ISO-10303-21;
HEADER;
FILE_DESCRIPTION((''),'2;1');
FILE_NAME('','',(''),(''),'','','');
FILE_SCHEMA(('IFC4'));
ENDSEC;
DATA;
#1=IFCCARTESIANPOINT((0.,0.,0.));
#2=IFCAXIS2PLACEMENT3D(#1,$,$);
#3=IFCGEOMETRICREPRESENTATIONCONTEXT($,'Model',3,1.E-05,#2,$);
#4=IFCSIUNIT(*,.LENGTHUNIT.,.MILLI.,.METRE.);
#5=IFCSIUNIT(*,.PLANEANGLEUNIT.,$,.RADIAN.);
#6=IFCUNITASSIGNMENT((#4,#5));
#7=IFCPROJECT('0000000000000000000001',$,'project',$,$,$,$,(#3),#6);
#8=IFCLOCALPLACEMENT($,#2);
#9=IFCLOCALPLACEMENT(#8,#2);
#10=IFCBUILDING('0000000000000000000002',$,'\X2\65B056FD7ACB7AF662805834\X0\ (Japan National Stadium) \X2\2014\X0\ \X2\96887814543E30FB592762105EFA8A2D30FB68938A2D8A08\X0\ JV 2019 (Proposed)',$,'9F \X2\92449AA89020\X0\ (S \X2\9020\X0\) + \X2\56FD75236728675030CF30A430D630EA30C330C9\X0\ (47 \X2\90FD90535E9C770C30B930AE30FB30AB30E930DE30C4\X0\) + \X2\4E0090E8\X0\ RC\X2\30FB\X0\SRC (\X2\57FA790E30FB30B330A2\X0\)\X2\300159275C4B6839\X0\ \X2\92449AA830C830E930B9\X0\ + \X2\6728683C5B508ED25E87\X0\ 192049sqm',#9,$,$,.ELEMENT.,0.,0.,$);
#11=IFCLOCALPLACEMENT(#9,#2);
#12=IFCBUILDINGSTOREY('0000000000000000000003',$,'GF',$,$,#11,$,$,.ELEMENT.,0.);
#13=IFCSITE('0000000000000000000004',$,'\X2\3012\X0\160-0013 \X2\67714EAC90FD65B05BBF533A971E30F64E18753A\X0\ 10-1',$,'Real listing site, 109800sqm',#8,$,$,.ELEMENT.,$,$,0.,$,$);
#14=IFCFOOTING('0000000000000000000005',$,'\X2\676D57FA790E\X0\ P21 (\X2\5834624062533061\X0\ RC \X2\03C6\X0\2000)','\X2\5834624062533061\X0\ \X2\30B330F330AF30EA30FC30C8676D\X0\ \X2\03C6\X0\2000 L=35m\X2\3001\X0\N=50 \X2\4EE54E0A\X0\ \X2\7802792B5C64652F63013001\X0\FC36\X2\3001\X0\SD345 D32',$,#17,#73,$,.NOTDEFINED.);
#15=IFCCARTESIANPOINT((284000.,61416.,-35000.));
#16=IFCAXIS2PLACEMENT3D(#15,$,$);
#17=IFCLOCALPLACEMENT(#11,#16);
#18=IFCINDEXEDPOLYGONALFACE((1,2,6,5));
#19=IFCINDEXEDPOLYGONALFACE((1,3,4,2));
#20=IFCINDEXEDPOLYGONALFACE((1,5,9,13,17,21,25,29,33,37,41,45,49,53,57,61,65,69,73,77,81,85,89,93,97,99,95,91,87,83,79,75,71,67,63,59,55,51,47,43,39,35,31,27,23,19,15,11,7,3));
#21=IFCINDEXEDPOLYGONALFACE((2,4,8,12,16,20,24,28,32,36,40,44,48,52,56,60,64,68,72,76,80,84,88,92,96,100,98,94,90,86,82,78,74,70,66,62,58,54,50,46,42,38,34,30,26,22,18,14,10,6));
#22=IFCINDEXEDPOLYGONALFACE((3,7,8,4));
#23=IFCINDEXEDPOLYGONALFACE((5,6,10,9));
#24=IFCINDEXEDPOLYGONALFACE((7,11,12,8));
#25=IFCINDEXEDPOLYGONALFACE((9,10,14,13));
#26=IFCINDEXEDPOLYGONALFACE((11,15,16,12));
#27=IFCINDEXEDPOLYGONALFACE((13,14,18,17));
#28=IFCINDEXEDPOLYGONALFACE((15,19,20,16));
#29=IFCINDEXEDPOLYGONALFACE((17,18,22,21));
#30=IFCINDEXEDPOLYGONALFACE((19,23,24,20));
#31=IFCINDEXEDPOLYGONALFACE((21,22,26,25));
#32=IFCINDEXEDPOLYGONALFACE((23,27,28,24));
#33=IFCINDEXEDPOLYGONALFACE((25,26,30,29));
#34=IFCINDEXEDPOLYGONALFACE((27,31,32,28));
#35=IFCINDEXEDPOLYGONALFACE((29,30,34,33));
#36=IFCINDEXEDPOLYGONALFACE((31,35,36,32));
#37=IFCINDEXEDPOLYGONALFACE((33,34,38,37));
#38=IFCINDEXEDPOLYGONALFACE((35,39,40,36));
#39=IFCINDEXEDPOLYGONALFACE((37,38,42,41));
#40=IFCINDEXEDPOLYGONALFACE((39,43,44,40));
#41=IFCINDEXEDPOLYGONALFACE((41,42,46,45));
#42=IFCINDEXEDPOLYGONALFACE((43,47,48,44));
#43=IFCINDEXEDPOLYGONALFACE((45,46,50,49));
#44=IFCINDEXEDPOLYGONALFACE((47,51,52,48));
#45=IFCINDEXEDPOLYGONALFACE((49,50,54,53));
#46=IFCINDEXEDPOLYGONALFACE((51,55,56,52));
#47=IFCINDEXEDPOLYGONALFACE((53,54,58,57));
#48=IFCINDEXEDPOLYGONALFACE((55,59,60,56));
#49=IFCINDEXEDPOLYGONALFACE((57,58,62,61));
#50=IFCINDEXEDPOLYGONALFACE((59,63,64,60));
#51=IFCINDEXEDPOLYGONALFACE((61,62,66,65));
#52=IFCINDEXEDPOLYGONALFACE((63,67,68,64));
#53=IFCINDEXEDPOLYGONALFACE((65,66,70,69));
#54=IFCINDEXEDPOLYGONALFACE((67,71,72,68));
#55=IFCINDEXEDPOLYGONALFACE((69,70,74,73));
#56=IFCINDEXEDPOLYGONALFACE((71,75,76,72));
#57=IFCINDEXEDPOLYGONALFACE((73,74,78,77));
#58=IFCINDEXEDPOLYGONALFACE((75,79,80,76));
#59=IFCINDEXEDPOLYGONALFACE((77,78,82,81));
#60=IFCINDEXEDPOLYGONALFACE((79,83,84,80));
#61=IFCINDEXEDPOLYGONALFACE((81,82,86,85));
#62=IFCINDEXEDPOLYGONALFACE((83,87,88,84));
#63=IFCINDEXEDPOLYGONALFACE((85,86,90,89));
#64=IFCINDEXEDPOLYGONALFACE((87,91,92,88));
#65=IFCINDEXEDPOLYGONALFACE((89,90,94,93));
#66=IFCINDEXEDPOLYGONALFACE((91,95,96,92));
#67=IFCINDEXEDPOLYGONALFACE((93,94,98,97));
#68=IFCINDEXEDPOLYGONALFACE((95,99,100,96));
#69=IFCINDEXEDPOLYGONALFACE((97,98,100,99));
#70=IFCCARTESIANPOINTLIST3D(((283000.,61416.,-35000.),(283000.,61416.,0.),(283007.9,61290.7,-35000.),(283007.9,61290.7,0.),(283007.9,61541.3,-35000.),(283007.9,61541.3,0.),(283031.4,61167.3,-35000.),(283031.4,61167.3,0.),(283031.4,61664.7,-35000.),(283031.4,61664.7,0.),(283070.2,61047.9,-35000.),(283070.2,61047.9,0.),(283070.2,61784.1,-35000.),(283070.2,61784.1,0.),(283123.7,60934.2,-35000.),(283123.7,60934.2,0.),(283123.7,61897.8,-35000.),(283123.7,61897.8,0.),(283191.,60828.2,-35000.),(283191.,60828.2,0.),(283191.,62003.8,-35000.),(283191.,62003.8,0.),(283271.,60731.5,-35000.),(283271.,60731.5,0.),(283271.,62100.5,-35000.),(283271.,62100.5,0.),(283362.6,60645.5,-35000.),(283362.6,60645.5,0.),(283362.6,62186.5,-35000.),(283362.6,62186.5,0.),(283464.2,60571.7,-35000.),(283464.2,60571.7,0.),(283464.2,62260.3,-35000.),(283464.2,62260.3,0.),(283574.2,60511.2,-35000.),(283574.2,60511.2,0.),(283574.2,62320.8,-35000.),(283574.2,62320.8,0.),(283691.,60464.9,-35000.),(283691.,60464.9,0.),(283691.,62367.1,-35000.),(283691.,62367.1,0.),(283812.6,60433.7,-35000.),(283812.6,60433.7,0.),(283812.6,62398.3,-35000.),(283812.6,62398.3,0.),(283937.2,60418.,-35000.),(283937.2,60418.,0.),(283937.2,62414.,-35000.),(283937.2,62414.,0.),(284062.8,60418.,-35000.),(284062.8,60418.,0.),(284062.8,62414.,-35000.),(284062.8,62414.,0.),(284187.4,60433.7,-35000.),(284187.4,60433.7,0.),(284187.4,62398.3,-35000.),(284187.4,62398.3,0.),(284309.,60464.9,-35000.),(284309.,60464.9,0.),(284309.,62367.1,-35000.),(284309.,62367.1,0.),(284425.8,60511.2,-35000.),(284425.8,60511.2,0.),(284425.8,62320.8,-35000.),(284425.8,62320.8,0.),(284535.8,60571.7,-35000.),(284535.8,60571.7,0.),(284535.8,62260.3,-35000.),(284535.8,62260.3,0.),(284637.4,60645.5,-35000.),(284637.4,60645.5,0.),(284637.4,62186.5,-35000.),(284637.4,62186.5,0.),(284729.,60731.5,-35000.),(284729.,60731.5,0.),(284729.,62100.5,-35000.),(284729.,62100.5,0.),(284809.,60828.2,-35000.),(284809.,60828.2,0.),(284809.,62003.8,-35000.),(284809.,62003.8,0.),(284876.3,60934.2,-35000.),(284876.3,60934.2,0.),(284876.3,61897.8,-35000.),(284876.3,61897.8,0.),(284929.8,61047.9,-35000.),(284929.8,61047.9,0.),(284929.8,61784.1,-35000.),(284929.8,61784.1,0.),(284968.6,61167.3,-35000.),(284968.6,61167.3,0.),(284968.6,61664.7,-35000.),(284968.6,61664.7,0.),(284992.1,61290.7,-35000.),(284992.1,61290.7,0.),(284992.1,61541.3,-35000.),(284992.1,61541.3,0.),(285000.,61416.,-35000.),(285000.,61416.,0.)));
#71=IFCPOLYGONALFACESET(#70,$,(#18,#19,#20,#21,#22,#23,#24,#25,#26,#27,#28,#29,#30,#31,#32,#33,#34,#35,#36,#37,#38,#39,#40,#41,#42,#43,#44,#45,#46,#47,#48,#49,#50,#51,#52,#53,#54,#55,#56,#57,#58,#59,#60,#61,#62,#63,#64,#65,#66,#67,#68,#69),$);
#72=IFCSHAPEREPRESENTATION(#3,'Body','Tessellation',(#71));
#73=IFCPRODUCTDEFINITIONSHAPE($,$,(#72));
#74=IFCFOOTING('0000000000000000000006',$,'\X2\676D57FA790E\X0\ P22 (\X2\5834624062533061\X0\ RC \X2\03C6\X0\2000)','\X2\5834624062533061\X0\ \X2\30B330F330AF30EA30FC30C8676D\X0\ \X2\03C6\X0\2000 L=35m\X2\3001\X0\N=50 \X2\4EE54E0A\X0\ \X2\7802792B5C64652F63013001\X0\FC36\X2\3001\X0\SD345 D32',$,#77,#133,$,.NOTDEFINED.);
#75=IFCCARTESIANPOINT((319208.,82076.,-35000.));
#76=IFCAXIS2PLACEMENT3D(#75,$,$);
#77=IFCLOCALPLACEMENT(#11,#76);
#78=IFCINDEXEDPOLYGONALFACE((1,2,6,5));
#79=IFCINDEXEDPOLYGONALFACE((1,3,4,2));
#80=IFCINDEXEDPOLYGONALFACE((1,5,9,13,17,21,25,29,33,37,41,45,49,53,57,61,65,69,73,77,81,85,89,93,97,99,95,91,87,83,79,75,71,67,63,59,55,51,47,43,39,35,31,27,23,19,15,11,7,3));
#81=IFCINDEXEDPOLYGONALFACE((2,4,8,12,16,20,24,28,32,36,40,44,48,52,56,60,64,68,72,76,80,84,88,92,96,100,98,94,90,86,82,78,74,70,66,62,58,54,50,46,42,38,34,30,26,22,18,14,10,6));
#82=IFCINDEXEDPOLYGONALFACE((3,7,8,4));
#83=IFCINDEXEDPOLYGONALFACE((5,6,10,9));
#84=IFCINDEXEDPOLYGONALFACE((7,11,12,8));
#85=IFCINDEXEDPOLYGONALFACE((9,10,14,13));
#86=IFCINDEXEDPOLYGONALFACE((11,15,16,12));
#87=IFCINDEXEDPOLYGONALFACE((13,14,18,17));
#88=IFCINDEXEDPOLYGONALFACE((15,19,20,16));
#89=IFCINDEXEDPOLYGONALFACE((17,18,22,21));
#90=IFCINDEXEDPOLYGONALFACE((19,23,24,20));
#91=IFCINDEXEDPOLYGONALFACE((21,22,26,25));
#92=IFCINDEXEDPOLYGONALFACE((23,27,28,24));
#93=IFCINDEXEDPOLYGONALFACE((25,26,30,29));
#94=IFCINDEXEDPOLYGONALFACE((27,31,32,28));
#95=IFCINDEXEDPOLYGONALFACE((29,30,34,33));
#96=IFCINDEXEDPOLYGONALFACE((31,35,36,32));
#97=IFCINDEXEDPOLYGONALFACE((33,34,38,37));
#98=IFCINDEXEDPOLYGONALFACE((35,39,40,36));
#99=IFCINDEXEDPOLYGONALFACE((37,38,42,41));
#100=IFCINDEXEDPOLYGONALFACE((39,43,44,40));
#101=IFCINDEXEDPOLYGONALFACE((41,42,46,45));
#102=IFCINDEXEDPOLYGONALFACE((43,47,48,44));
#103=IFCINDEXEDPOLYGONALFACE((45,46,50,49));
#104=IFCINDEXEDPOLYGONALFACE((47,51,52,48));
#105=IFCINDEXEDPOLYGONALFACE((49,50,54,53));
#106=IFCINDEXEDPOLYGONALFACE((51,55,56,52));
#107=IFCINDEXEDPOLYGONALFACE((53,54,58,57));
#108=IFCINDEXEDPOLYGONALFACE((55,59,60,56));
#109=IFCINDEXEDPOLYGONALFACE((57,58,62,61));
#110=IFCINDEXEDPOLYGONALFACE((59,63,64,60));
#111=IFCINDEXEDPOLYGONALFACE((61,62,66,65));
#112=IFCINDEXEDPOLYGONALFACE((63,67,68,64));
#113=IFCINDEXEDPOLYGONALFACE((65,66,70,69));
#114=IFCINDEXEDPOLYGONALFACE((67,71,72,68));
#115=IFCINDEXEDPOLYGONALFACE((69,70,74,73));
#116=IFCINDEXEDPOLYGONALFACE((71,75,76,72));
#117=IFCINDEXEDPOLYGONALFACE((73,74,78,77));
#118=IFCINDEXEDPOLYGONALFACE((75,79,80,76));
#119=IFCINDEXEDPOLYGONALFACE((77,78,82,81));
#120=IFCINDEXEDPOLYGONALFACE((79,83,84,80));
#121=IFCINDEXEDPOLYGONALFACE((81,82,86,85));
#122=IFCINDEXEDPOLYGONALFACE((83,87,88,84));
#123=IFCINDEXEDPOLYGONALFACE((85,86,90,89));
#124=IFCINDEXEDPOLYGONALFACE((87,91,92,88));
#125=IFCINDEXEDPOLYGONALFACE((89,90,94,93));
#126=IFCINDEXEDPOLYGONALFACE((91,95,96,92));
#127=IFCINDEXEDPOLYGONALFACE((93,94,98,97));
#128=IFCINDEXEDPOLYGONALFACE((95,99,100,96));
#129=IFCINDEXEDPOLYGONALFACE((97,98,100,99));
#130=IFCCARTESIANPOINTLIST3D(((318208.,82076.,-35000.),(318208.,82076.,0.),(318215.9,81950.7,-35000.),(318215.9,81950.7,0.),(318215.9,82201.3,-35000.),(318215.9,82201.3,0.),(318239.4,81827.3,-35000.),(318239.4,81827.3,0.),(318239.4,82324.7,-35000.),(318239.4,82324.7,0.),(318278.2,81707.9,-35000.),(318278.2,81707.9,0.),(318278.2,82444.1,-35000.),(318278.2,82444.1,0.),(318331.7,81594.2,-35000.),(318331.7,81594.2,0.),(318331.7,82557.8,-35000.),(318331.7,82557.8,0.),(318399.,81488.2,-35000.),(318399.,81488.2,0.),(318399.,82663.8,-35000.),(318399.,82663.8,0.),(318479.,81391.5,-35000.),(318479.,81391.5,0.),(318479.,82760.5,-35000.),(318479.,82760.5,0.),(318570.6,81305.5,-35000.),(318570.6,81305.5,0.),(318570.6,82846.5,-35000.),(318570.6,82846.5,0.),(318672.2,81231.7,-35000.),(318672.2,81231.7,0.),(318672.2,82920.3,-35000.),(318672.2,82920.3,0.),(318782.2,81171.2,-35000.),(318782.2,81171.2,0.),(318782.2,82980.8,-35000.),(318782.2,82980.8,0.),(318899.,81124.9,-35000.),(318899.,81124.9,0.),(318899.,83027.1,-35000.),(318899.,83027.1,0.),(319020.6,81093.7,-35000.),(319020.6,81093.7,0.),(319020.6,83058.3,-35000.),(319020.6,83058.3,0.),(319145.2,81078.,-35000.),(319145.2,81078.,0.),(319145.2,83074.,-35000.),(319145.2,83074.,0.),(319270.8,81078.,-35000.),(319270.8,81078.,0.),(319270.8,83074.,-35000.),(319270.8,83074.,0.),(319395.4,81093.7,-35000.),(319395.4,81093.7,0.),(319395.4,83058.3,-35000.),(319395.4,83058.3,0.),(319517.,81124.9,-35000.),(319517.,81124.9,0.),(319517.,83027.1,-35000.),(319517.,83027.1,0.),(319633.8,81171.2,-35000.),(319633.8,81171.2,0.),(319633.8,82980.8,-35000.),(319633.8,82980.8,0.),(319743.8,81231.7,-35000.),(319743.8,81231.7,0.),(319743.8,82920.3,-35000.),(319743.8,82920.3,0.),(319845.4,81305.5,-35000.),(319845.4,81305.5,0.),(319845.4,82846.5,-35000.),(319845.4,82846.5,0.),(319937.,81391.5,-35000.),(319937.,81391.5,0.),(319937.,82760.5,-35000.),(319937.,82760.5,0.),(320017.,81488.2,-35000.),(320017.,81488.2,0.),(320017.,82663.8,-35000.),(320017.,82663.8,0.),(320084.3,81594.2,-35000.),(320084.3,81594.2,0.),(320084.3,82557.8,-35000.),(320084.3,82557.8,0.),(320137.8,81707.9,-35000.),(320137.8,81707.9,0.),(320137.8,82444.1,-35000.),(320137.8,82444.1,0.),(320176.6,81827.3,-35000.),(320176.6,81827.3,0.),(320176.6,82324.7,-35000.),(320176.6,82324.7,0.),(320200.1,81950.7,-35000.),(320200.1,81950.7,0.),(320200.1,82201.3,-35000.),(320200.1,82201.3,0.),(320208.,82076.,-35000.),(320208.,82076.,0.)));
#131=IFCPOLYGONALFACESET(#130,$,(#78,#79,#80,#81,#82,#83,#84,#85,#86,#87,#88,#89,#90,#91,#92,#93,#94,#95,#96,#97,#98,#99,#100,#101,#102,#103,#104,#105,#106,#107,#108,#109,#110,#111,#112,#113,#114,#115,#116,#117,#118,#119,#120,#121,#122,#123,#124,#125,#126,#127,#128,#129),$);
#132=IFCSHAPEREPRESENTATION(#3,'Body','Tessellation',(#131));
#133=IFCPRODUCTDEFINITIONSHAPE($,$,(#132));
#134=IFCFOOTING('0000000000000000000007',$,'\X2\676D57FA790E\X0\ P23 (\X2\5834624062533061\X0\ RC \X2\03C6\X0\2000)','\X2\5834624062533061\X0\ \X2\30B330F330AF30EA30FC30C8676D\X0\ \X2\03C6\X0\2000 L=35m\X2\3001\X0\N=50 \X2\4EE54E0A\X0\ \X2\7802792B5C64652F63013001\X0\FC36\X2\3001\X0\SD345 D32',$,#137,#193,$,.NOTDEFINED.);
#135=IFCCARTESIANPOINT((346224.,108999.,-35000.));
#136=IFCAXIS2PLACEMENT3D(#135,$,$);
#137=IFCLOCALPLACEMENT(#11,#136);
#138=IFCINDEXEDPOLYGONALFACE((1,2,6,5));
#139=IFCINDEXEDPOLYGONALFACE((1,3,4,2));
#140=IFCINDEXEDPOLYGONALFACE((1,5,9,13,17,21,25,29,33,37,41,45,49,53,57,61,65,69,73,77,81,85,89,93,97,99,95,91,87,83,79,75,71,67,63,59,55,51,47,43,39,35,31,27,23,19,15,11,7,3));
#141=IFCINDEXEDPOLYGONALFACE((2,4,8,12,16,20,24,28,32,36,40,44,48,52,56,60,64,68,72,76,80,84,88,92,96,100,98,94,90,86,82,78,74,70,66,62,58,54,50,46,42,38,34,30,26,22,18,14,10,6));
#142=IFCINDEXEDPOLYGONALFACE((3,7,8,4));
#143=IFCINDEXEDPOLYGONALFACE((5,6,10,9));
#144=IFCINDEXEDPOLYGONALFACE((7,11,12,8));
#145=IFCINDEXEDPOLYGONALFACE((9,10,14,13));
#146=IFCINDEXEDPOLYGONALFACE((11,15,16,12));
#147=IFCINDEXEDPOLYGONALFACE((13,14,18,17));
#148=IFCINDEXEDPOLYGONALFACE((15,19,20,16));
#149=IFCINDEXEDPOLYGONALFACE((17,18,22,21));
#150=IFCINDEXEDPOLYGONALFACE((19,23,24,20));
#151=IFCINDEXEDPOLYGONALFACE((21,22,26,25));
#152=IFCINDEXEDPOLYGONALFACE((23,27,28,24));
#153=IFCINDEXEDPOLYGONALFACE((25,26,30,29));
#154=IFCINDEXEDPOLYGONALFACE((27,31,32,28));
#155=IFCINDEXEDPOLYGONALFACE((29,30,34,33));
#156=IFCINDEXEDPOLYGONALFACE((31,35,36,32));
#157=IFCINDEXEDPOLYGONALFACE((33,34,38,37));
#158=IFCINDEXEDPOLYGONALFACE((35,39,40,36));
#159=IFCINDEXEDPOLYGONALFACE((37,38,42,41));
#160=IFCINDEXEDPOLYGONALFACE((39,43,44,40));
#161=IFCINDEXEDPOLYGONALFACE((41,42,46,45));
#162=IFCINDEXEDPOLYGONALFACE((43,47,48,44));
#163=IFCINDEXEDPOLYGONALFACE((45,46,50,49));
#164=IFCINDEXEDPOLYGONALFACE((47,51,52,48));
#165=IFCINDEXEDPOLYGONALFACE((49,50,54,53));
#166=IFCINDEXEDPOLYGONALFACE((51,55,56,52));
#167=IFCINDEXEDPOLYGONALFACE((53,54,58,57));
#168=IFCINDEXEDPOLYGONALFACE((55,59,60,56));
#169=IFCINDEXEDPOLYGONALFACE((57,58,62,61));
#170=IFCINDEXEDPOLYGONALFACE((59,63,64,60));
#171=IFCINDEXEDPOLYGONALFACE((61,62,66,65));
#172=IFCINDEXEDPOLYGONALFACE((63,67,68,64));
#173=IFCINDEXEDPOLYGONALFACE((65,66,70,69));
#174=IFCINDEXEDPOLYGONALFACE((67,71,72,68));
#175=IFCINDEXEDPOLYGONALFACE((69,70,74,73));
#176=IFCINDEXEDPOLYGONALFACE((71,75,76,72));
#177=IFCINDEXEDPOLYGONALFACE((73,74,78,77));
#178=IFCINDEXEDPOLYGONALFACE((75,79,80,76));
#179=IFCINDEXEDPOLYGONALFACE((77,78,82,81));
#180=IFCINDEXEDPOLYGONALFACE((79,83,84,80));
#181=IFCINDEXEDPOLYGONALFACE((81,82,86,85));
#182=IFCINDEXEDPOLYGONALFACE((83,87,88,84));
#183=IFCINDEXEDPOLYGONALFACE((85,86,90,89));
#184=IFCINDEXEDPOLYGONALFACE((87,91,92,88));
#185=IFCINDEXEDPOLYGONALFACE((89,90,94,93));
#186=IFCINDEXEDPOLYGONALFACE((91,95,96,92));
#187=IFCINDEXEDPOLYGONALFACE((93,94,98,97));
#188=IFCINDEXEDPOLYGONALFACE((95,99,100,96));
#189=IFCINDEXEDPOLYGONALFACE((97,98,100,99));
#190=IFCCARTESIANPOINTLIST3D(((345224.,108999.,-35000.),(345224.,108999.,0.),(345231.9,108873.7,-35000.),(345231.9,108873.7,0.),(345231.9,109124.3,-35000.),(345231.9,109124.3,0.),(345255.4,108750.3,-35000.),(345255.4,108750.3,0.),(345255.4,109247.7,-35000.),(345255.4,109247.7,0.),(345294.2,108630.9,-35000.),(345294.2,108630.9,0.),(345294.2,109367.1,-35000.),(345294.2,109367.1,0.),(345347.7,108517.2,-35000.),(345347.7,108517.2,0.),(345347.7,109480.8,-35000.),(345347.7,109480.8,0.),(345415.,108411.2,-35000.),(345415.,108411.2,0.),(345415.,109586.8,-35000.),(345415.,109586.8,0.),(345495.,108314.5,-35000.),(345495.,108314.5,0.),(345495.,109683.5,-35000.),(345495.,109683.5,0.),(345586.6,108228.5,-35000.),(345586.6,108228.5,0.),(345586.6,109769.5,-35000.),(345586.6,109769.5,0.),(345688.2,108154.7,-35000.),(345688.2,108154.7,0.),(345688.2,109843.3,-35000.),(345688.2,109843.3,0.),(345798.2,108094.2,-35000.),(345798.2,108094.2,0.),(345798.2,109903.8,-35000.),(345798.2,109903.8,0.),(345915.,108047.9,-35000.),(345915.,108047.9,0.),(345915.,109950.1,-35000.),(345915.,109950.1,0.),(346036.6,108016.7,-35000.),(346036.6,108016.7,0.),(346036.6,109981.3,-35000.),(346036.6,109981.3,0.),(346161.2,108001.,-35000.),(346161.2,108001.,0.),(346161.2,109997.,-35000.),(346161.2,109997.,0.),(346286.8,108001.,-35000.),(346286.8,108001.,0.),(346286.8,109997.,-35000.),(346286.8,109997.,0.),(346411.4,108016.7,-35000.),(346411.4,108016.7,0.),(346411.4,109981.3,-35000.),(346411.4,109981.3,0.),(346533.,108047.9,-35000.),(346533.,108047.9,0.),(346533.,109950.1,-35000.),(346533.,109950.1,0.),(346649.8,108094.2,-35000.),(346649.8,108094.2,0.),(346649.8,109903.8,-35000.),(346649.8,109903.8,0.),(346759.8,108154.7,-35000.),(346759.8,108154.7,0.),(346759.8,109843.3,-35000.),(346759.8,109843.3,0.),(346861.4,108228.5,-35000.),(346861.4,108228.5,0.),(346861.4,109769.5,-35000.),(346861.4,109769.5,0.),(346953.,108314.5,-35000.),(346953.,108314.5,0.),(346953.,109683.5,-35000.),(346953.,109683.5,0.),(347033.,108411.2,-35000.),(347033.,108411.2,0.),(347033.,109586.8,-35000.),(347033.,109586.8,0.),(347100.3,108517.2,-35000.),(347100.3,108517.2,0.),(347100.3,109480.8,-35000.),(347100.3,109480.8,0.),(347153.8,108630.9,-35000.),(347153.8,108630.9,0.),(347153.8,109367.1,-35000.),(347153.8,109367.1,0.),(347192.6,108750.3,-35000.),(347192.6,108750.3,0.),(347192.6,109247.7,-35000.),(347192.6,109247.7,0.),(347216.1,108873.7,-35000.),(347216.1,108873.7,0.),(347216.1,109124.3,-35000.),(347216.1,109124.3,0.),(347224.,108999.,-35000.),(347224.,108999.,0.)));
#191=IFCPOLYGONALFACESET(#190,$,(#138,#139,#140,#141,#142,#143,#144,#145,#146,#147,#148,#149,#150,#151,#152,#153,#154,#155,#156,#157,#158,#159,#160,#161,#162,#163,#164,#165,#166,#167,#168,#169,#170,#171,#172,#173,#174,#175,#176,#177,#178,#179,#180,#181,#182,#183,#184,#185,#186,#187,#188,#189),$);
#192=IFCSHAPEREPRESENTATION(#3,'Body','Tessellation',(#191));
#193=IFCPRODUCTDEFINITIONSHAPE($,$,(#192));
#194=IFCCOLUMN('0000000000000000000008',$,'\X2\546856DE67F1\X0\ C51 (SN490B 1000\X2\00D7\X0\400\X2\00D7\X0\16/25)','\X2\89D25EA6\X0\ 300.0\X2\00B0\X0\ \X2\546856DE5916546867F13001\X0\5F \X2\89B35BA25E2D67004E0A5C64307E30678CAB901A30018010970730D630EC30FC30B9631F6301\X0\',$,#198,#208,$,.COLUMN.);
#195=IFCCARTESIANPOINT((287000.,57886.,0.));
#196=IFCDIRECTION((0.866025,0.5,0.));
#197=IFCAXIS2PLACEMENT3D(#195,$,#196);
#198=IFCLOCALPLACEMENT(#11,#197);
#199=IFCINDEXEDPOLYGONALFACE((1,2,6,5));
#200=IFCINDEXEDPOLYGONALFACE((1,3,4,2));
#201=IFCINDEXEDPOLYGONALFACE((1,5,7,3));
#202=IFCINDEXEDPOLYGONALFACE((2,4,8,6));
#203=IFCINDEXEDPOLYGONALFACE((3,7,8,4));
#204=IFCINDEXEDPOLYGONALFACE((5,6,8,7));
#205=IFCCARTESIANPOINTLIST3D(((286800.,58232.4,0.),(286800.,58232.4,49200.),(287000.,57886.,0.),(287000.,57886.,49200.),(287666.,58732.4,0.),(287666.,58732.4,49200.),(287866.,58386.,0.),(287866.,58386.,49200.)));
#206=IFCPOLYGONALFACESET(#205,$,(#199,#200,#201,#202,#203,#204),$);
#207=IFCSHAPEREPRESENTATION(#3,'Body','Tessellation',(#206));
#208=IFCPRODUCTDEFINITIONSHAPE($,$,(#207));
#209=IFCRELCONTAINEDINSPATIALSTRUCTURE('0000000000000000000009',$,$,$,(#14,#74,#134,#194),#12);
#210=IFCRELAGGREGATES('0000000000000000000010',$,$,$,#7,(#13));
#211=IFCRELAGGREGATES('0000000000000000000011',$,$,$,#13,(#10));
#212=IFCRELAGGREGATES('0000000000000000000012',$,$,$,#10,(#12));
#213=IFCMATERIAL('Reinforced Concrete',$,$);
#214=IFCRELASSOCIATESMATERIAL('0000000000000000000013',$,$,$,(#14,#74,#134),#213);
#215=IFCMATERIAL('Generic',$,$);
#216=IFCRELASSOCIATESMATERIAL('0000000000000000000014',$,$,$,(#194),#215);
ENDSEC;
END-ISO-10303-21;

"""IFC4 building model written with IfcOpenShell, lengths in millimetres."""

from ifc_helpers import new_model, si_unit, frame, frame_2d, origin, origin_2d, place, context, project, spatial, rectangle, circle, extrude, material, element, save


model = new_model("IFC4")

# Units and contexts
model_context = context("Model", 3, precision=1e-05, world=origin())
ifc_project = project(units=[si_unit("LENGTHUNIT", "METRE", prefix="MILLI"), si_unit("PLANEANGLEUNIT", "RADIAN")], contexts=[model_context])

# Site, building, storey
site_placement = place(None, origin())
site = spatial("IfcSite", under=ifc_project, at=site_placement, Name="〒160-0013 東京都新宿区霞ヶ丘町 10-1", ObjectType="Real listing site, 109800sqm", CompositionType="ELEMENT", RefElevation=0.0)
building_placement = place(site_placement, origin())
building = spatial("IfcBuilding", under=site, at=building_placement, Name="新国立競技場 (Japan National Stadium) — 隈研吾・大成建設・梓設計 JV 2019 (Proposed)", ObjectType="9F 鉄骨造 (S 造) + 国産木材ハイブリッド (47 都道府県スギ・カラマツ) + 一部 RC・SRC (基礎・コア)、大屋根 鉄骨トラス + 木格子軒庇 192049sqm", CompositionType="ELEMENT", ElevationOfRefHeight=0.0, ElevationOfTerrain=0.0)
storey_placement = place(building_placement, origin())
storey = spatial("IfcBuildingStorey", under=building, at=storey_placement, Name="GF", CompositionType="ELEMENT", Elevation=0.0)

# Footings
ifc_material_1 = material(Name="Reinforced Concrete")
footing_1_placement = place(storey_placement, frame((284000.0, 61416.0, -35000.0)))
element("IfcFooting", 1, at=footing_1_placement, inside=storey, material=ifc_material_1, Name="杭基礎 P21 (場所打ち RC φ2000)", Description="場所打ち コンクリート杭 φ2000 L=35m、N=50 以上 砂礫層支持、FC36、SD345 D32", PredefinedType="NOTDEFINED", context=model_context, shape_type="SweptSolid", body=[
    extrude(circle(Radius=1000.0, at=origin_2d()), frame((284000.0, 61416.0, -35000.0)), (0.0, 0.0, 1.0), 35000.0),
])
footing_2_placement = place(storey_placement, frame((319208.0, 82076.0, -35000.0)))
element("IfcFooting", 2, at=footing_2_placement, inside=storey, material=ifc_material_1, Name="杭基礎 P22 (場所打ち RC φ2000)", Description="場所打ち コンクリート杭 φ2000 L=35m、N=50 以上 砂礫層支持、FC36、SD345 D32", PredefinedType="NOTDEFINED", context=model_context, shape_type="SweptSolid", body=[
    extrude(circle(Radius=1000.0, at=origin_2d()), frame((319208.0, 82076.0, -35000.0)), (0.0, 0.0, 1.0), 35000.0),
])
footing_3_placement = place(storey_placement, frame((346224.0, 108999.0, -35000.0)))
element("IfcFooting", 3, at=footing_3_placement, inside=storey, material=ifc_material_1, Name="杭基礎 P23 (場所打ち RC φ2000)", Description="場所打ち コンクリート杭 φ2000 L=35m、N=50 以上 砂礫層支持、FC36、SD345 D32", PredefinedType="NOTDEFINED", context=model_context, shape_type="SweptSolid", body=[
    extrude(circle(Radius=1000.0, at=origin_2d()), frame((346224.0, 108999.0, -35000.0)), (0.0, 0.0, 1.0), 35000.0),
])

# Column
ifc_material_2 = material(Name="Generic")
column_1_placement = place(storey_placement, frame((287000.0, 57886.0, 0.0), x_axis=(0.866025, 0.5, 0.0)))
element("IfcColumn", 4, at=column_1_placement, inside=storey, material=ifc_material_2, Name="周回柱 C51 (SN490B 1000×400×16/25)", Description="角度 300.0° 周回外周柱、5F 観客席最上層まで貫通、耐震ブレース挟持", PredefinedType="COLUMN", context=model_context, shape_type="SweptSolid", body=[
    extrude(rectangle(XDim=1000.0, YDim=400.0, at=frame_2d((500.0, 200.0))), frame((287000.0, 57886.0, 0.0), x_axis=(0.866025, 0.5, 0.0)), (0.0, 0.0, 1.0), 49200.0),
])

save(model, "model.ifc")
